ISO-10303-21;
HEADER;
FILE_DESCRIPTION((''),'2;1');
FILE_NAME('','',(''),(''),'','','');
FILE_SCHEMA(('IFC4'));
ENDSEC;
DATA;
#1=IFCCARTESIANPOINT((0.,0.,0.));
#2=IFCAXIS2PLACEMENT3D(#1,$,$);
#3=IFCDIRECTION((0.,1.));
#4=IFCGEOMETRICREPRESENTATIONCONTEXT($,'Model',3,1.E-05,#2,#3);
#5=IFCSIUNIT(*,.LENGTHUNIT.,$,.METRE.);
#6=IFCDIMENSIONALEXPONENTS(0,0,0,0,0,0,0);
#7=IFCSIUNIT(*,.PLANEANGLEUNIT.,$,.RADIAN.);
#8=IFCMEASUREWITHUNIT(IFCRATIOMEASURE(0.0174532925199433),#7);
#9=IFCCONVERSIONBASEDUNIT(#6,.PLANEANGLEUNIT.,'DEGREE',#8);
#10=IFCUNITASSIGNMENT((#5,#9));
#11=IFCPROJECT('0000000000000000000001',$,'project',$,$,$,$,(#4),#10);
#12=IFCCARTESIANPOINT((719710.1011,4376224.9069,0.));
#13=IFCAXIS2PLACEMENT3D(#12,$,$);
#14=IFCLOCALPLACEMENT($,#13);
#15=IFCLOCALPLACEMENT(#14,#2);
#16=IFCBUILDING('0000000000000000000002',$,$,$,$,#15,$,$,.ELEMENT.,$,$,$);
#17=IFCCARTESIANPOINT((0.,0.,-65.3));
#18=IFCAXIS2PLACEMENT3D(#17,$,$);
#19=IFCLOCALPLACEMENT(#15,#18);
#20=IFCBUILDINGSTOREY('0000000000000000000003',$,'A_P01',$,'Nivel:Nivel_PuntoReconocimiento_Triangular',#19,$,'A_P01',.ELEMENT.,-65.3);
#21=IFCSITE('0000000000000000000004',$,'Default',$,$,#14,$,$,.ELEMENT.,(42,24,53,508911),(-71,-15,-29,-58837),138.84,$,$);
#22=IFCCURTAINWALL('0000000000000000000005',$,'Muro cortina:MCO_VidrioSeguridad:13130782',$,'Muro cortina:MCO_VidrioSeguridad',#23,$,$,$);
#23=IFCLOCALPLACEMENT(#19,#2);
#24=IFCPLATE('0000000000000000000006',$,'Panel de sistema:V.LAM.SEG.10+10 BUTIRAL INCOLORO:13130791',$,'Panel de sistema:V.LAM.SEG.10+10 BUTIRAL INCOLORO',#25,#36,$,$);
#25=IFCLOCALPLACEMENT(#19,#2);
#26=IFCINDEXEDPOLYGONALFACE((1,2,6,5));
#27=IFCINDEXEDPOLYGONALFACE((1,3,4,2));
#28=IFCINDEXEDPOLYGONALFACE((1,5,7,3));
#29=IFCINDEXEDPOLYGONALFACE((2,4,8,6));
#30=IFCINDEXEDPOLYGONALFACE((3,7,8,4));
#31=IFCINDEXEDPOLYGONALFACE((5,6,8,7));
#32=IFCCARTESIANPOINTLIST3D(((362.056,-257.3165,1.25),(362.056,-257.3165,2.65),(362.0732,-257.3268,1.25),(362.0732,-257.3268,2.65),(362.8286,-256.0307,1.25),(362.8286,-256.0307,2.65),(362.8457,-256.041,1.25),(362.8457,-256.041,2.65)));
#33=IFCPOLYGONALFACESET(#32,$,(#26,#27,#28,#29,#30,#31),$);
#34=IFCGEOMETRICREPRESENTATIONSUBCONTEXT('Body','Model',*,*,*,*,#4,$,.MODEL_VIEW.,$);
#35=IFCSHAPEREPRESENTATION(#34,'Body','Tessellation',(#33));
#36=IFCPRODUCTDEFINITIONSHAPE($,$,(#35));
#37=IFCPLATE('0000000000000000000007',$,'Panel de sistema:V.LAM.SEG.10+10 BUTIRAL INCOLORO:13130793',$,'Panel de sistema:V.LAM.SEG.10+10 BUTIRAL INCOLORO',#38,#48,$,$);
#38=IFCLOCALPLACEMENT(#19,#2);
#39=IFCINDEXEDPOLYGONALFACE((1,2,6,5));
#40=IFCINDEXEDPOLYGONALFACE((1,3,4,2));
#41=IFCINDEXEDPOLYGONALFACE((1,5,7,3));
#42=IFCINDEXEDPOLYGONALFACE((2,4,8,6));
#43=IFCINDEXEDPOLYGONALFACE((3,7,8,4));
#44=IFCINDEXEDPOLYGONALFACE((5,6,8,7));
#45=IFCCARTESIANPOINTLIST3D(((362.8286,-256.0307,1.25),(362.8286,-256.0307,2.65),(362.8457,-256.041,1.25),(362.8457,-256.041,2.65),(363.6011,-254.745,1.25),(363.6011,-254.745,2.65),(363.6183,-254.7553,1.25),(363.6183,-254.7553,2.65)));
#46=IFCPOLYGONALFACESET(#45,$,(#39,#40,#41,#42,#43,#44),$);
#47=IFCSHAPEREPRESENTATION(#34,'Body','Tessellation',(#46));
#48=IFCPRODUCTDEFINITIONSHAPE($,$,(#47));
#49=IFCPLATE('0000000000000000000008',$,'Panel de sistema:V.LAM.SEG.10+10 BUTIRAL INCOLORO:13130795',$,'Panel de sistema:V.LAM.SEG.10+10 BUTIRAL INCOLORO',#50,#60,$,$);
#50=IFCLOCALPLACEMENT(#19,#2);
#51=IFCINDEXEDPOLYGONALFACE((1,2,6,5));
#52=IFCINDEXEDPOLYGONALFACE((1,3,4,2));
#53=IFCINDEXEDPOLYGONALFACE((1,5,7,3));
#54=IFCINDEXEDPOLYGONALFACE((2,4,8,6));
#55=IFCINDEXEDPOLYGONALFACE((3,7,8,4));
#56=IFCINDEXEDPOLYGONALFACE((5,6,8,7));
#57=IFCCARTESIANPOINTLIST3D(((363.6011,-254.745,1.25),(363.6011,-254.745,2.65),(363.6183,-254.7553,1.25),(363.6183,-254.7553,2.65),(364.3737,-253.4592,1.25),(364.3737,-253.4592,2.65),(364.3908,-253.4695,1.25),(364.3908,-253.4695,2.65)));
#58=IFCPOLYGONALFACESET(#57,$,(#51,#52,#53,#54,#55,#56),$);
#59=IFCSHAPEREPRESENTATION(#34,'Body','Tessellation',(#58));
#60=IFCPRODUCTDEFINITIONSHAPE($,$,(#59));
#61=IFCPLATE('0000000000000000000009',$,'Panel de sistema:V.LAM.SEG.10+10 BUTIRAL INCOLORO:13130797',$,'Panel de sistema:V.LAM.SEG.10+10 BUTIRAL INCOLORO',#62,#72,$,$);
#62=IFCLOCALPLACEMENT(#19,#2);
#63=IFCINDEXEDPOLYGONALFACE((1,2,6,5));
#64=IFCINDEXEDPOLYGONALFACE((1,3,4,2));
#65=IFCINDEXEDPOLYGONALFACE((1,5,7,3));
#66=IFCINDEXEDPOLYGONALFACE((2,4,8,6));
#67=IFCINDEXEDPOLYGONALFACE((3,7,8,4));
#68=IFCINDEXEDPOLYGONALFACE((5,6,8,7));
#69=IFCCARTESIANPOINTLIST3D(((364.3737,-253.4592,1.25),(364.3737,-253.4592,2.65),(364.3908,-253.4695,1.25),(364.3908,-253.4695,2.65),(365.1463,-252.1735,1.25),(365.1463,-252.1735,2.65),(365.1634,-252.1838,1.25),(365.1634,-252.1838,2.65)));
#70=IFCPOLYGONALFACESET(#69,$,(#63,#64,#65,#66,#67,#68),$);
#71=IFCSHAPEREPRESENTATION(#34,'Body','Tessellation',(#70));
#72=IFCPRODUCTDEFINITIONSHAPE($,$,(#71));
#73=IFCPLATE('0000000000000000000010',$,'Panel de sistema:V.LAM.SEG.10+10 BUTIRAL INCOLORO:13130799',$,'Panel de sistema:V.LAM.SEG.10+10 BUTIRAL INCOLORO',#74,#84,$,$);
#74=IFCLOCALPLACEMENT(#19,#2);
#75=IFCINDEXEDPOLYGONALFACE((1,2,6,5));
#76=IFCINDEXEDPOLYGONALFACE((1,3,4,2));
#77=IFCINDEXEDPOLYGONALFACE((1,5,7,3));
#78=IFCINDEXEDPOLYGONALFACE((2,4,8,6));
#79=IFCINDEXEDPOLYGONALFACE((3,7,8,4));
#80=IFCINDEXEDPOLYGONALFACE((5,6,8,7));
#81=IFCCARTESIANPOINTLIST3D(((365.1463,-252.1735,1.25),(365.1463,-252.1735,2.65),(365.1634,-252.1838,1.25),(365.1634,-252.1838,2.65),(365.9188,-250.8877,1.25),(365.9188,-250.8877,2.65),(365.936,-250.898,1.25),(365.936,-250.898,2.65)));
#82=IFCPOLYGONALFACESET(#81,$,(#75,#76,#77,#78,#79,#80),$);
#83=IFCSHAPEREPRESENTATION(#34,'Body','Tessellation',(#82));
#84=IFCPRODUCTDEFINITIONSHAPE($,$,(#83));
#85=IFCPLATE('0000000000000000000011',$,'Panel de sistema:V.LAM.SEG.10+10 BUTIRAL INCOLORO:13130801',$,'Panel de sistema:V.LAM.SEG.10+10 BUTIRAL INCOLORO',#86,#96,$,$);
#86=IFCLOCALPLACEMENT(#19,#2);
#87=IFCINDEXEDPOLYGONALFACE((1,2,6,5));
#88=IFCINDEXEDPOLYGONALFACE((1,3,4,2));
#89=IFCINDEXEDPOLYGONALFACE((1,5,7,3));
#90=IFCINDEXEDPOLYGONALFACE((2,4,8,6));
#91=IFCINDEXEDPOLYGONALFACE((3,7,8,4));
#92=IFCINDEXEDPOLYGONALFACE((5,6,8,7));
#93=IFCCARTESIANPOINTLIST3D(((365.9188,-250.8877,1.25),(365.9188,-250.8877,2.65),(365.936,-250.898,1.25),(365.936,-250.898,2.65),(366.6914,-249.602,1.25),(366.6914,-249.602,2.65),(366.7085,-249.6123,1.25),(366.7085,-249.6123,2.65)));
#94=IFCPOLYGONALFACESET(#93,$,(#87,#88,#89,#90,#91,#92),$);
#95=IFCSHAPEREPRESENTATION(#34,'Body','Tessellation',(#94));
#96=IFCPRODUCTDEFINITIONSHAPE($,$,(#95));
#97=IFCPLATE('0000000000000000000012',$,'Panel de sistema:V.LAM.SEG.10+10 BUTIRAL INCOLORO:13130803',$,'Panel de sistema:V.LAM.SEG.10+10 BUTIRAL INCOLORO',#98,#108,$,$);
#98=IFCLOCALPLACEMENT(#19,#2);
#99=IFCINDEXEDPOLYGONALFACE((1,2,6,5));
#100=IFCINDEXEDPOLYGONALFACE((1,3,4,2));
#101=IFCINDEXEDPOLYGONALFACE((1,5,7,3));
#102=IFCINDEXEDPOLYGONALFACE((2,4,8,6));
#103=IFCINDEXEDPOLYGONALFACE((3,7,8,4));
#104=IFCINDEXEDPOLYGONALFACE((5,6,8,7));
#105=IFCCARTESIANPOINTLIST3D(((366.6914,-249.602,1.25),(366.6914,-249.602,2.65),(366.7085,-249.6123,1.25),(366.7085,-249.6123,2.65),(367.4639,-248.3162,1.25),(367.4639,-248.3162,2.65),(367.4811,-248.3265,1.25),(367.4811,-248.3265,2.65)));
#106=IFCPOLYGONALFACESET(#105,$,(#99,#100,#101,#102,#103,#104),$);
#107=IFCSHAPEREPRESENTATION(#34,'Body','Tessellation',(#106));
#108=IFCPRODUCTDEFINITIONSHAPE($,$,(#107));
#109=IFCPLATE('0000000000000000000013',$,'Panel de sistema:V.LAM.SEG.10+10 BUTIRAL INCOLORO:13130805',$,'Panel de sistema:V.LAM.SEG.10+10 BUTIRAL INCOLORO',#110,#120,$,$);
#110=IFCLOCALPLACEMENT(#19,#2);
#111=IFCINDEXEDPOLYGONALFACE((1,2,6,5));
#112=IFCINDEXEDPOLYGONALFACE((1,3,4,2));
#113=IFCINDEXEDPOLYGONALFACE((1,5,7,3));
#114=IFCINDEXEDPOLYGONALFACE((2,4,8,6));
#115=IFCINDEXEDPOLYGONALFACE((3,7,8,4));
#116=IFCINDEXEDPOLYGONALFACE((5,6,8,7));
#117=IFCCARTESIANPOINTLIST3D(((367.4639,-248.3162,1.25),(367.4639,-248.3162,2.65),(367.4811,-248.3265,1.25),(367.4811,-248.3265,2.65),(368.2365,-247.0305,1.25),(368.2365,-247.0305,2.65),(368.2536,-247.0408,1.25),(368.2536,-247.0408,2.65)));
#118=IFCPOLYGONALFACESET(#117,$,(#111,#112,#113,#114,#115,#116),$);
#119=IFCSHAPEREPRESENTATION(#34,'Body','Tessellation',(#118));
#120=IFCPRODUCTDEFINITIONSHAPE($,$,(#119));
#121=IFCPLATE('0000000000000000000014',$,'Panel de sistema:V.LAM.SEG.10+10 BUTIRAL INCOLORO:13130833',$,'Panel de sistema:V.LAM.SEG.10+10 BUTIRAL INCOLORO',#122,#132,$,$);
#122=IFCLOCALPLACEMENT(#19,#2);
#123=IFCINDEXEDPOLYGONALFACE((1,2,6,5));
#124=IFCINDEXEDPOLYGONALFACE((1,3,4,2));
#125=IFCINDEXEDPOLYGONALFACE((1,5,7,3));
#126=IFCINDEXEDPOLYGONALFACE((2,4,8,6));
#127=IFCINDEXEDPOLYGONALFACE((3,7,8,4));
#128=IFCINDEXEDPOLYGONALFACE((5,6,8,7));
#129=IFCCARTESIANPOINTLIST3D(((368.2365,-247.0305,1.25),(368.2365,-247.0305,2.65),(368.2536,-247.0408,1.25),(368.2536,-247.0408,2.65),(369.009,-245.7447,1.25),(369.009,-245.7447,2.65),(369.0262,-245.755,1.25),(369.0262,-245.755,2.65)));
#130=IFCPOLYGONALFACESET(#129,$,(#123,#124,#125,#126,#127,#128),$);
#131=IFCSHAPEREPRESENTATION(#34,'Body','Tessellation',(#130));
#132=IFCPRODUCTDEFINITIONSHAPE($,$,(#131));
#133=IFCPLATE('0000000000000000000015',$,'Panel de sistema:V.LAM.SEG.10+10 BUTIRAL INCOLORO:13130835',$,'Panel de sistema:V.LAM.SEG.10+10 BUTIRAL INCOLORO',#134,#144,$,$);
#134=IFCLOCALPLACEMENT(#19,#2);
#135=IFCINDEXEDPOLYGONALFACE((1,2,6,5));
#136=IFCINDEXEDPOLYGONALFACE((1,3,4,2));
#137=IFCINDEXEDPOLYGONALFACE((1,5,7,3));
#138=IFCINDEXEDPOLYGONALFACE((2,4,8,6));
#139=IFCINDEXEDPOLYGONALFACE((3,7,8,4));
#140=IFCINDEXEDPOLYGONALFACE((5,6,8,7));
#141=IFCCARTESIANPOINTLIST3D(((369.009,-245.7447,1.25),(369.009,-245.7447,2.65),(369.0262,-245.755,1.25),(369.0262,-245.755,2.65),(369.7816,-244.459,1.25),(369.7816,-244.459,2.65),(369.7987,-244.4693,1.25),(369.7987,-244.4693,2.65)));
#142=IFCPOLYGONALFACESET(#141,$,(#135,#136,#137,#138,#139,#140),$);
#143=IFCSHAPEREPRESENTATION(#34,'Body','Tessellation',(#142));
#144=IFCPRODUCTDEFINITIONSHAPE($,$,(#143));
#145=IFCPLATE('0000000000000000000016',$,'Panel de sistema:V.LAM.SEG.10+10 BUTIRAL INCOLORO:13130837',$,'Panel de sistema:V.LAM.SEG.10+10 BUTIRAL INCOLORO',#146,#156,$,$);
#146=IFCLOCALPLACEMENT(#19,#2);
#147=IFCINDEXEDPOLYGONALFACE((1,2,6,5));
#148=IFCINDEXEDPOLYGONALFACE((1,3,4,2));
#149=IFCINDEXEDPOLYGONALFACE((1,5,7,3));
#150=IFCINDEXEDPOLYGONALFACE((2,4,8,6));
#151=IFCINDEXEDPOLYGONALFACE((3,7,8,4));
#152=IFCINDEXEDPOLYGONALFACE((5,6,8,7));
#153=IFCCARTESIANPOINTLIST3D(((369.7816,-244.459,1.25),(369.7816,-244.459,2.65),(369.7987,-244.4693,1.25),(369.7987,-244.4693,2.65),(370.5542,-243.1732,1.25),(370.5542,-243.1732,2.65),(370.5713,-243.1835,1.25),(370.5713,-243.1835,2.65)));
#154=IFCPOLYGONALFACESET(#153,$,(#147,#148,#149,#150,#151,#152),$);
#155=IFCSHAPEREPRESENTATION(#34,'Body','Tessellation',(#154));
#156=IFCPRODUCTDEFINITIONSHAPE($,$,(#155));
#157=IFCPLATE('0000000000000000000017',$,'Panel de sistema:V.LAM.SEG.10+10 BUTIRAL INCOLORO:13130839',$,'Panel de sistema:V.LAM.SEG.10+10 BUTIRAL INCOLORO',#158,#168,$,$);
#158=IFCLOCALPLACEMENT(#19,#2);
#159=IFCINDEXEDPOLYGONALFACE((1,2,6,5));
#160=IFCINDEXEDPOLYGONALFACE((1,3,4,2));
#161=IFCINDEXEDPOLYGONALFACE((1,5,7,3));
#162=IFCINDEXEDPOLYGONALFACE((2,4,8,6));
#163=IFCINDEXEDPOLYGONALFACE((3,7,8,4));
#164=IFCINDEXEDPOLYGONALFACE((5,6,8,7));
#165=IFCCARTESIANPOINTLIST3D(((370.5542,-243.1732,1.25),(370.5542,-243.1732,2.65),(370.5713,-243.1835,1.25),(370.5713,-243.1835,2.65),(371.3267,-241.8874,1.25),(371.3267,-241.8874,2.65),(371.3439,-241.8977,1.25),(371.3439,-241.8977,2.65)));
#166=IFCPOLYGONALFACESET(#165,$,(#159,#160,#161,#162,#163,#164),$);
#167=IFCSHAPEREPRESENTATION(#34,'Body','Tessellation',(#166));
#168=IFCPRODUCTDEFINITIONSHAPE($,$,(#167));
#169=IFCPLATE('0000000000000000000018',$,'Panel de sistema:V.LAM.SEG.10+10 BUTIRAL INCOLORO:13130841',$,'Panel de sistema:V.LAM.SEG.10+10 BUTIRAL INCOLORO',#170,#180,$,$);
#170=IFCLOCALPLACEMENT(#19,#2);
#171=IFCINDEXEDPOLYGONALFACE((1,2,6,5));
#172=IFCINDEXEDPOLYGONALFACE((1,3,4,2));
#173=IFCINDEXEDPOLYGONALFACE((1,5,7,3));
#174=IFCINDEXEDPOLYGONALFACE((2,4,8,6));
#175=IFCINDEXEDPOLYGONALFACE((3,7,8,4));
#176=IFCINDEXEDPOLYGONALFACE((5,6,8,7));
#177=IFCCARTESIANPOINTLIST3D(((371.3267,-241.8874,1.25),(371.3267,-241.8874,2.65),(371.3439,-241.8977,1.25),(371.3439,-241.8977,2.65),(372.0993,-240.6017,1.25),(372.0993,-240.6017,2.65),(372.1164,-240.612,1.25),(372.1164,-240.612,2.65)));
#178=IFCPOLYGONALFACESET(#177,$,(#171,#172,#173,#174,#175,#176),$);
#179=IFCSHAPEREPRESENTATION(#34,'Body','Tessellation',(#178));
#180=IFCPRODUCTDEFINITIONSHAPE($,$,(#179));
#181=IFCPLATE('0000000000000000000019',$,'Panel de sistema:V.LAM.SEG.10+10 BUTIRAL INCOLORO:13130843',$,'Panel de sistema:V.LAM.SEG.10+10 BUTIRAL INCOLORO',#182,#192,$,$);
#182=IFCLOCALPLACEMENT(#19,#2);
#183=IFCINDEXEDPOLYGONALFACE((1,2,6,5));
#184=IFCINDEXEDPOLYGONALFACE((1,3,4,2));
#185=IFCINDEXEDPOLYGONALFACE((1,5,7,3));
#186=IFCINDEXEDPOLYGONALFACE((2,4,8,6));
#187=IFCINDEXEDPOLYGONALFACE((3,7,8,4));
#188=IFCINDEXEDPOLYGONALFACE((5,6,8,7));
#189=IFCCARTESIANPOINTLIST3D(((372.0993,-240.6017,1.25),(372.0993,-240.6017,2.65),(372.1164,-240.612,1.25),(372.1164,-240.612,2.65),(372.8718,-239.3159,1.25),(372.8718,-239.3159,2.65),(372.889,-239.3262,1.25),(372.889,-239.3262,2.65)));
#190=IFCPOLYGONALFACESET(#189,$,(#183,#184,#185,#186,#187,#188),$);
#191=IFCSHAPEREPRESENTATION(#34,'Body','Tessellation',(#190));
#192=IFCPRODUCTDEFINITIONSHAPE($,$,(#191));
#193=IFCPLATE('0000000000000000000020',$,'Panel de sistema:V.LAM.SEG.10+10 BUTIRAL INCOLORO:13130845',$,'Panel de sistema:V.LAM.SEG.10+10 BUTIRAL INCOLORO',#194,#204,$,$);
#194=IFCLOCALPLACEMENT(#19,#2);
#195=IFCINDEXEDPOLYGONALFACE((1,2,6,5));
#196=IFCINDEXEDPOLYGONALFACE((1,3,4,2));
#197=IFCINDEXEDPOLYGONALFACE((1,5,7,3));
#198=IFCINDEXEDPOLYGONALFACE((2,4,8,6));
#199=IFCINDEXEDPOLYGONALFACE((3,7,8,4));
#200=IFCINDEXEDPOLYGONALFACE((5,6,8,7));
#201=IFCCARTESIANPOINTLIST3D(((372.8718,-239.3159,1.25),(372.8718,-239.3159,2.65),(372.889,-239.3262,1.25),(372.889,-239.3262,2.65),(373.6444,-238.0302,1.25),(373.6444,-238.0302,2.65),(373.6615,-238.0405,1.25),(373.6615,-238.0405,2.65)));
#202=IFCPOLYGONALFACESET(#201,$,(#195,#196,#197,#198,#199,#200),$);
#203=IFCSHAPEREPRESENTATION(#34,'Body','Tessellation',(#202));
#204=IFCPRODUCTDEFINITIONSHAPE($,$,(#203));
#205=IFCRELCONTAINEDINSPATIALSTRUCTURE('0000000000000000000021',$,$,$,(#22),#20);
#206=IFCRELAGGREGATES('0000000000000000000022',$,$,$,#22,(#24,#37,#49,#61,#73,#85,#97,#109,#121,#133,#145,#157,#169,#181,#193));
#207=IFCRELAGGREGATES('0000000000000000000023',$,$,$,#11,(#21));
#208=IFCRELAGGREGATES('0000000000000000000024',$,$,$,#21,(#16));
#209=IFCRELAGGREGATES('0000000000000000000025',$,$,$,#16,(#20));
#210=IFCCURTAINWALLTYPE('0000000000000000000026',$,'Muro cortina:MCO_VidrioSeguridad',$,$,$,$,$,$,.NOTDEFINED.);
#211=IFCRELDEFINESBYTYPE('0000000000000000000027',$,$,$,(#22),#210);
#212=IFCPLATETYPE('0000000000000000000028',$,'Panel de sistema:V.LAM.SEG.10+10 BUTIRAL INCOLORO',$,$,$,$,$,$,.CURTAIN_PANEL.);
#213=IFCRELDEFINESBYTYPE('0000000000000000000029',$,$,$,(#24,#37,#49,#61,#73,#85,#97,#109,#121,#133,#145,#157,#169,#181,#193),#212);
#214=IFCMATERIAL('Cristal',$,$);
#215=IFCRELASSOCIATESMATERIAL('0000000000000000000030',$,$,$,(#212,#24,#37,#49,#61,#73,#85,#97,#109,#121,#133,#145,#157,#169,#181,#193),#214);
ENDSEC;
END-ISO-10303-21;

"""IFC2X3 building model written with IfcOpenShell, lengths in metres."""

from ifc_helpers import new_model, entity, si_unit, converted_unit, direction, frame, origin, origin_2d_with_axis, place, context, subcontext, project, spatial, rectangle, extrude, source, transform, mapped, material, type_object, type_shapes, element, aggregate, save


model = new_model("IFC2X3")

# Units and contexts
model_context = context("Model", 3, precision=1e-05, world=origin(), true_north=direction((0.0, 1.0)))
body_context = subcontext(model_context, "Body", "Model", "MODEL_VIEW")
ifc_project = project(units=[si_unit("LENGTHUNIT", "METRE"), converted_unit("PLANEANGLEUNIT", "DEGREE", entity("IfcRatioMeasure", 0.0174532925199433), si_unit("PLANEANGLEUNIT", "RADIAN"), dimensions=[0, 0, 0, 0, 0, 0, 0])], contexts=[model_context])

# Site, building, storey
site_placement = place(None, frame((719710.1011, 4376224.9069, 0.0)))
site = spatial("IfcSite", under=ifc_project, at=site_placement, Name="Default", CompositionType="ELEMENT", RefLatitude=(42, 24, 53, 508911), RefLongitude=(-71, -15, -29, -58837), RefElevation=138.84)
building_placement = place(site_placement, origin())
building = spatial("IfcBuilding", under=site, at=building_placement, CompositionType="ELEMENT")
storey_placement = place(building_placement, frame((0.0, 0.0, -65.3)))
storey = spatial("IfcBuildingStorey", under=building, at=storey_placement, Name="A_P01", ObjectType="Nivel:Nivel_PuntoReconocimiento_Triangular", LongName="A_P01", CompositionType="ELEMENT", Elevation=-65.3)

# Curtain wall, plates
curtain_wall_type = type_object("IfcCurtainWallType", Name="Muro cortina:MCO_VidrioSeguridad", PredefinedType="NOTDEFINED")
curtain_wall_placement = place(storey_placement, frame((0.0, 0.0, 65.3)))
curtain_wall = element("IfcCurtainWall", 1, at=curtain_wall_placement, inside=storey, type_object=curtain_wall_type, Name="Muro cortina:MCO_VidrioSeguridad:13130782", ObjectType="Muro cortina:MCO_VidrioSeguridad")
ifc_material_1 = material(Name="Cristal")
plate_type_1 = type_object("IfcPlateType", Name="Panel de sistema:V.LAM.SEG.10+10 BUTIRAL INCOLORO", PredefinedType="CURTAIN_PANEL", material=ifc_material_1)
shared_shape_1 = source(origin(), body_context, "Body", "SweptSolid", [
    extrude(rectangle(XDim=0.02, YDim=1.5, at=origin_2d_with_axis()), frame((0.0, 0.0, 0.0), z_axis=(0.0, 0.0, 1.0), x_axis=(0.0, 1.0, 0.0)), (0.0, 0.0, 1.0), 1.4),
])
type_shapes(plate_type_1, [shared_shape_1])
plate_1_placement = place(curtain_wall_placement, frame((362.4509, -256.6787, -64.05), z_axis=(0.0, 0.0, 1.0), x_axis=(0.515038, 0.857167, 0.0)))
plate_1 = element("IfcPlate", 2, at=plate_1_placement, type_object=plate_type_1, material=ifc_material_1, Name="Panel de sistema:V.LAM.SEG.10+10 BUTIRAL INCOLORO:13130791", ObjectType="Panel de sistema:V.LAM.SEG.10+10 BUTIRAL INCOLORO", context=body_context, shape_type="MappedRepresentation", body=[
    mapped(shared_shape_1, transform((0.0, 0.0, 0.0), scale=1.0)),
])
plate_2_placement = place(curtain_wall_placement, frame((363.2234, -255.393, -64.05), z_axis=(0.0, 0.0, 1.0), x_axis=(0.515038, 0.857167, 0.0)))
plate_2 = element("IfcPlate", 3, at=plate_2_placement, type_object=plate_type_1, material=ifc_material_1, Name="Panel de sistema:V.LAM.SEG.10+10 BUTIRAL INCOLORO:13130793", ObjectType="Panel de sistema:V.LAM.SEG.10+10 BUTIRAL INCOLORO", context=body_context, shape_type="MappedRepresentation", body=[
    mapped(shared_shape_1, transform((0.0, 0.0, 0.0), scale=1.0)),
])
plate_3_placement = place(curtain_wall_placement, frame((363.996, -254.1072, -64.05), z_axis=(0.0, 0.0, 1.0), x_axis=(0.515038, 0.857167, 0.0)))
plate_3 = element("IfcPlate", 4, at=plate_3_placement, type_object=plate_type_1, material=ifc_material_1, Name="Panel de sistema:V.LAM.SEG.10+10 BUTIRAL INCOLORO:13130795", ObjectType="Panel de sistema:V.LAM.SEG.10+10 BUTIRAL INCOLORO", context=body_context, shape_type="MappedRepresentation", body=[
    mapped(shared_shape_1, transform((0.0, 0.0, 0.0), scale=1.0)),
])
plate_4_placement = place(curtain_wall_placement, frame((364.7685, -252.8215, -64.05), z_axis=(0.0, 0.0, 1.0), x_axis=(0.515038, 0.857167, 0.0)))
plate_4 = element("IfcPlate", 5, at=plate_4_placement, type_object=plate_type_1, material=ifc_material_1, Name="Panel de sistema:V.LAM.SEG.10+10 BUTIRAL INCOLORO:13130797", ObjectType="Panel de sistema:V.LAM.SEG.10+10 BUTIRAL INCOLORO", context=body_context, shape_type="MappedRepresentation", body=[
    mapped(shared_shape_1, transform((0.0, 0.0, 0.0), scale=1.0)),
])
plate_5_placement = place(curtain_wall_placement, frame((365.5411, -251.5357, -64.05), z_axis=(0.0, 0.0, 1.0), x_axis=(0.515038, 0.857167, 0.0)))
plate_5 = element("IfcPlate", 6, at=plate_5_placement, type_object=plate_type_1, material=ifc_material_1, Name="Panel de sistema:V.LAM.SEG.10+10 BUTIRAL INCOLORO:13130799", ObjectType="Panel de sistema:V.LAM.SEG.10+10 BUTIRAL INCOLORO", context=body_context, shape_type="MappedRepresentation", body=[
    mapped(shared_shape_1, transform((0.0, 0.0, 0.0), scale=1.0)),
])
plate_6_placement = place(curtain_wall_placement, frame((366.3137, -250.25, -64.05), z_axis=(0.0, 0.0, 1.0), x_axis=(0.515038, 0.857167, 0.0)))
plate_6 = element("IfcPlate", 7, at=plate_6_placement, type_object=plate_type_1, material=ifc_material_1, Name="Panel de sistema:V.LAM.SEG.10+10 BUTIRAL INCOLORO:13130801", ObjectType="Panel de sistema:V.LAM.SEG.10+10 BUTIRAL INCOLORO", context=body_context, shape_type="MappedRepresentation", body=[
    mapped(shared_shape_1, transform((0.0, 0.0, 0.0), scale=1.0)),
])
plate_7_placement = place(curtain_wall_placement, frame((367.0862, -248.9642, -64.05), z_axis=(0.0, 0.0, 1.0), x_axis=(0.515038, 0.857167, 0.0)))
plate_7 = element("IfcPlate", 8, at=plate_7_placement, type_object=plate_type_1, material=ifc_material_1, Name="Panel de sistema:V.LAM.SEG.10+10 BUTIRAL INCOLORO:13130803", ObjectType="Panel de sistema:V.LAM.SEG.10+10 BUTIRAL INCOLORO", context=body_context, shape_type="MappedRepresentation", body=[
    mapped(shared_shape_1, transform((0.0, 0.0, 0.0), scale=1.0)),
])
plate_8_placement = place(curtain_wall_placement, frame((367.8588, -247.6785, -64.05), z_axis=(0.0, 0.0, 1.0), x_axis=(0.515038, 0.857167, 0.0)))
plate_8 = element("IfcPlate", 9, at=plate_8_placement, type_object=plate_type_1, material=ifc_material_1, Name="Panel de sistema:V.LAM.SEG.10+10 BUTIRAL INCOLORO:13130805", ObjectType="Panel de sistema:V.LAM.SEG.10+10 BUTIRAL INCOLORO", context=body_context, shape_type="MappedRepresentation", body=[
    mapped(shared_shape_1, transform((0.0, 0.0, 0.0), scale=1.0)),
])
plate_9_placement = place(curtain_wall_placement, frame((368.6313, -246.3927, -64.05), z_axis=(0.0, 0.0, 1.0), x_axis=(0.515038, 0.857167, 0.0)))
plate_9 = element("IfcPlate", 10, at=plate_9_placement, type_object=plate_type_1, material=ifc_material_1, Name="Panel de sistema:V.LAM.SEG.10+10 BUTIRAL INCOLORO:13130833", ObjectType="Panel de sistema:V.LAM.SEG.10+10 BUTIRAL INCOLORO", context=body_context, shape_type="MappedRepresentation", body=[
    mapped(shared_shape_1, transform((0.0, 0.0, 0.0), scale=1.0)),
])
plate_10_placement = place(curtain_wall_placement, frame((369.4039, -245.107, -64.05), z_axis=(0.0, 0.0, 1.0), x_axis=(0.515038, 0.857167, 0.0)))
plate_10 = element("IfcPlate", 11, at=plate_10_placement, type_object=plate_type_1, material=ifc_material_1, Name="Panel de sistema:V.LAM.SEG.10+10 BUTIRAL INCOLORO:13130835", ObjectType="Panel de sistema:V.LAM.SEG.10+10 BUTIRAL INCOLORO", context=body_context, shape_type="MappedRepresentation", body=[
    mapped(shared_shape_1, transform((0.0, 0.0, 0.0), scale=1.0)),
])
plate_11_placement = place(curtain_wall_placement, frame((370.1764, -243.8212, -64.05), z_axis=(0.0, 0.0, 1.0), x_axis=(0.515038, 0.857167, 0.0)))
plate_11 = element("IfcPlate", 12, at=plate_11_placement, type_object=plate_type_1, material=ifc_material_1, Name="Panel de sistema:V.LAM.SEG.10+10 BUTIRAL INCOLORO:13130837", ObjectType="Panel de sistema:V.LAM.SEG.10+10 BUTIRAL INCOLORO", context=body_context, shape_type="MappedRepresentation", body=[
    mapped(shared_shape_1, transform((0.0, 0.0, 0.0), scale=1.0)),
])
plate_12_placement = place(curtain_wall_placement, frame((370.949, -242.5355, -64.05), z_axis=(0.0, 0.0, 1.0), x_axis=(0.515038, 0.857167, 0.0)))
plate_12 = element("IfcPlate", 13, at=plate_12_placement, type_object=plate_type_1, material=ifc_material_1, Name="Panel de sistema:V.LAM.SEG.10+10 BUTIRAL INCOLORO:13130839", ObjectType="Panel de sistema:V.LAM.SEG.10+10 BUTIRAL INCOLORO", context=body_context, shape_type="MappedRepresentation", body=[
    mapped(shared_shape_1, transform((0.0, 0.0, 0.0), scale=1.0)),
])
plate_13_placement = place(curtain_wall_placement, frame((371.7216, -241.2497, -64.05), z_axis=(0.0, 0.0, 1.0), x_axis=(0.515038, 0.857167, 0.0)))
plate_13 = element("IfcPlate", 14, at=plate_13_placement, type_object=plate_type_1, material=ifc_material_1, Name="Panel de sistema:V.LAM.SEG.10+10 BUTIRAL INCOLORO:13130841", ObjectType="Panel de sistema:V.LAM.SEG.10+10 BUTIRAL INCOLORO", context=body_context, shape_type="MappedRepresentation", body=[
    mapped(shared_shape_1, transform((0.0, 0.0, 0.0), scale=1.0)),
])
plate_14_placement = place(curtain_wall_placement, frame((372.4941, -239.964, -64.05), z_axis=(0.0, 0.0, 1.0), x_axis=(0.515038, 0.857167, 0.0)))
plate_14 = element("IfcPlate", 15, at=plate_14_placement, type_object=plate_type_1, material=ifc_material_1, Name="Panel de sistema:V.LAM.SEG.10+10 BUTIRAL INCOLORO:13130843", ObjectType="Panel de sistema:V.LAM.SEG.10+10 BUTIRAL INCOLORO", context=body_context, shape_type="MappedRepresentation", body=[
    mapped(shared_shape_1, transform((0.0, 0.0, 0.0), scale=1.0)),
])
plate_15_placement = place(curtain_wall_placement, frame((373.2667, -238.6782, -64.05), z_axis=(0.0, 0.0, 1.0), x_axis=(0.515038, 0.857167, 0.0)))
plate_15 = element("IfcPlate", 16, at=plate_15_placement, type_object=plate_type_1, material=ifc_material_1, Name="Panel de sistema:V.LAM.SEG.10+10 BUTIRAL INCOLORO:13130845", ObjectType="Panel de sistema:V.LAM.SEG.10+10 BUTIRAL INCOLORO", context=body_context, shape_type="MappedRepresentation", body=[
    mapped(shared_shape_1, transform((0.0, 0.0, 0.0), scale=1.0)),
])
aggregate(curtain_wall, [plate_1, plate_2, plate_3, plate_4, plate_5, plate_6, plate_7, plate_8, plate_9, plate_10, plate_11, plate_12, plate_13, plate_14, plate_15])

save(model, "model.ifc")
